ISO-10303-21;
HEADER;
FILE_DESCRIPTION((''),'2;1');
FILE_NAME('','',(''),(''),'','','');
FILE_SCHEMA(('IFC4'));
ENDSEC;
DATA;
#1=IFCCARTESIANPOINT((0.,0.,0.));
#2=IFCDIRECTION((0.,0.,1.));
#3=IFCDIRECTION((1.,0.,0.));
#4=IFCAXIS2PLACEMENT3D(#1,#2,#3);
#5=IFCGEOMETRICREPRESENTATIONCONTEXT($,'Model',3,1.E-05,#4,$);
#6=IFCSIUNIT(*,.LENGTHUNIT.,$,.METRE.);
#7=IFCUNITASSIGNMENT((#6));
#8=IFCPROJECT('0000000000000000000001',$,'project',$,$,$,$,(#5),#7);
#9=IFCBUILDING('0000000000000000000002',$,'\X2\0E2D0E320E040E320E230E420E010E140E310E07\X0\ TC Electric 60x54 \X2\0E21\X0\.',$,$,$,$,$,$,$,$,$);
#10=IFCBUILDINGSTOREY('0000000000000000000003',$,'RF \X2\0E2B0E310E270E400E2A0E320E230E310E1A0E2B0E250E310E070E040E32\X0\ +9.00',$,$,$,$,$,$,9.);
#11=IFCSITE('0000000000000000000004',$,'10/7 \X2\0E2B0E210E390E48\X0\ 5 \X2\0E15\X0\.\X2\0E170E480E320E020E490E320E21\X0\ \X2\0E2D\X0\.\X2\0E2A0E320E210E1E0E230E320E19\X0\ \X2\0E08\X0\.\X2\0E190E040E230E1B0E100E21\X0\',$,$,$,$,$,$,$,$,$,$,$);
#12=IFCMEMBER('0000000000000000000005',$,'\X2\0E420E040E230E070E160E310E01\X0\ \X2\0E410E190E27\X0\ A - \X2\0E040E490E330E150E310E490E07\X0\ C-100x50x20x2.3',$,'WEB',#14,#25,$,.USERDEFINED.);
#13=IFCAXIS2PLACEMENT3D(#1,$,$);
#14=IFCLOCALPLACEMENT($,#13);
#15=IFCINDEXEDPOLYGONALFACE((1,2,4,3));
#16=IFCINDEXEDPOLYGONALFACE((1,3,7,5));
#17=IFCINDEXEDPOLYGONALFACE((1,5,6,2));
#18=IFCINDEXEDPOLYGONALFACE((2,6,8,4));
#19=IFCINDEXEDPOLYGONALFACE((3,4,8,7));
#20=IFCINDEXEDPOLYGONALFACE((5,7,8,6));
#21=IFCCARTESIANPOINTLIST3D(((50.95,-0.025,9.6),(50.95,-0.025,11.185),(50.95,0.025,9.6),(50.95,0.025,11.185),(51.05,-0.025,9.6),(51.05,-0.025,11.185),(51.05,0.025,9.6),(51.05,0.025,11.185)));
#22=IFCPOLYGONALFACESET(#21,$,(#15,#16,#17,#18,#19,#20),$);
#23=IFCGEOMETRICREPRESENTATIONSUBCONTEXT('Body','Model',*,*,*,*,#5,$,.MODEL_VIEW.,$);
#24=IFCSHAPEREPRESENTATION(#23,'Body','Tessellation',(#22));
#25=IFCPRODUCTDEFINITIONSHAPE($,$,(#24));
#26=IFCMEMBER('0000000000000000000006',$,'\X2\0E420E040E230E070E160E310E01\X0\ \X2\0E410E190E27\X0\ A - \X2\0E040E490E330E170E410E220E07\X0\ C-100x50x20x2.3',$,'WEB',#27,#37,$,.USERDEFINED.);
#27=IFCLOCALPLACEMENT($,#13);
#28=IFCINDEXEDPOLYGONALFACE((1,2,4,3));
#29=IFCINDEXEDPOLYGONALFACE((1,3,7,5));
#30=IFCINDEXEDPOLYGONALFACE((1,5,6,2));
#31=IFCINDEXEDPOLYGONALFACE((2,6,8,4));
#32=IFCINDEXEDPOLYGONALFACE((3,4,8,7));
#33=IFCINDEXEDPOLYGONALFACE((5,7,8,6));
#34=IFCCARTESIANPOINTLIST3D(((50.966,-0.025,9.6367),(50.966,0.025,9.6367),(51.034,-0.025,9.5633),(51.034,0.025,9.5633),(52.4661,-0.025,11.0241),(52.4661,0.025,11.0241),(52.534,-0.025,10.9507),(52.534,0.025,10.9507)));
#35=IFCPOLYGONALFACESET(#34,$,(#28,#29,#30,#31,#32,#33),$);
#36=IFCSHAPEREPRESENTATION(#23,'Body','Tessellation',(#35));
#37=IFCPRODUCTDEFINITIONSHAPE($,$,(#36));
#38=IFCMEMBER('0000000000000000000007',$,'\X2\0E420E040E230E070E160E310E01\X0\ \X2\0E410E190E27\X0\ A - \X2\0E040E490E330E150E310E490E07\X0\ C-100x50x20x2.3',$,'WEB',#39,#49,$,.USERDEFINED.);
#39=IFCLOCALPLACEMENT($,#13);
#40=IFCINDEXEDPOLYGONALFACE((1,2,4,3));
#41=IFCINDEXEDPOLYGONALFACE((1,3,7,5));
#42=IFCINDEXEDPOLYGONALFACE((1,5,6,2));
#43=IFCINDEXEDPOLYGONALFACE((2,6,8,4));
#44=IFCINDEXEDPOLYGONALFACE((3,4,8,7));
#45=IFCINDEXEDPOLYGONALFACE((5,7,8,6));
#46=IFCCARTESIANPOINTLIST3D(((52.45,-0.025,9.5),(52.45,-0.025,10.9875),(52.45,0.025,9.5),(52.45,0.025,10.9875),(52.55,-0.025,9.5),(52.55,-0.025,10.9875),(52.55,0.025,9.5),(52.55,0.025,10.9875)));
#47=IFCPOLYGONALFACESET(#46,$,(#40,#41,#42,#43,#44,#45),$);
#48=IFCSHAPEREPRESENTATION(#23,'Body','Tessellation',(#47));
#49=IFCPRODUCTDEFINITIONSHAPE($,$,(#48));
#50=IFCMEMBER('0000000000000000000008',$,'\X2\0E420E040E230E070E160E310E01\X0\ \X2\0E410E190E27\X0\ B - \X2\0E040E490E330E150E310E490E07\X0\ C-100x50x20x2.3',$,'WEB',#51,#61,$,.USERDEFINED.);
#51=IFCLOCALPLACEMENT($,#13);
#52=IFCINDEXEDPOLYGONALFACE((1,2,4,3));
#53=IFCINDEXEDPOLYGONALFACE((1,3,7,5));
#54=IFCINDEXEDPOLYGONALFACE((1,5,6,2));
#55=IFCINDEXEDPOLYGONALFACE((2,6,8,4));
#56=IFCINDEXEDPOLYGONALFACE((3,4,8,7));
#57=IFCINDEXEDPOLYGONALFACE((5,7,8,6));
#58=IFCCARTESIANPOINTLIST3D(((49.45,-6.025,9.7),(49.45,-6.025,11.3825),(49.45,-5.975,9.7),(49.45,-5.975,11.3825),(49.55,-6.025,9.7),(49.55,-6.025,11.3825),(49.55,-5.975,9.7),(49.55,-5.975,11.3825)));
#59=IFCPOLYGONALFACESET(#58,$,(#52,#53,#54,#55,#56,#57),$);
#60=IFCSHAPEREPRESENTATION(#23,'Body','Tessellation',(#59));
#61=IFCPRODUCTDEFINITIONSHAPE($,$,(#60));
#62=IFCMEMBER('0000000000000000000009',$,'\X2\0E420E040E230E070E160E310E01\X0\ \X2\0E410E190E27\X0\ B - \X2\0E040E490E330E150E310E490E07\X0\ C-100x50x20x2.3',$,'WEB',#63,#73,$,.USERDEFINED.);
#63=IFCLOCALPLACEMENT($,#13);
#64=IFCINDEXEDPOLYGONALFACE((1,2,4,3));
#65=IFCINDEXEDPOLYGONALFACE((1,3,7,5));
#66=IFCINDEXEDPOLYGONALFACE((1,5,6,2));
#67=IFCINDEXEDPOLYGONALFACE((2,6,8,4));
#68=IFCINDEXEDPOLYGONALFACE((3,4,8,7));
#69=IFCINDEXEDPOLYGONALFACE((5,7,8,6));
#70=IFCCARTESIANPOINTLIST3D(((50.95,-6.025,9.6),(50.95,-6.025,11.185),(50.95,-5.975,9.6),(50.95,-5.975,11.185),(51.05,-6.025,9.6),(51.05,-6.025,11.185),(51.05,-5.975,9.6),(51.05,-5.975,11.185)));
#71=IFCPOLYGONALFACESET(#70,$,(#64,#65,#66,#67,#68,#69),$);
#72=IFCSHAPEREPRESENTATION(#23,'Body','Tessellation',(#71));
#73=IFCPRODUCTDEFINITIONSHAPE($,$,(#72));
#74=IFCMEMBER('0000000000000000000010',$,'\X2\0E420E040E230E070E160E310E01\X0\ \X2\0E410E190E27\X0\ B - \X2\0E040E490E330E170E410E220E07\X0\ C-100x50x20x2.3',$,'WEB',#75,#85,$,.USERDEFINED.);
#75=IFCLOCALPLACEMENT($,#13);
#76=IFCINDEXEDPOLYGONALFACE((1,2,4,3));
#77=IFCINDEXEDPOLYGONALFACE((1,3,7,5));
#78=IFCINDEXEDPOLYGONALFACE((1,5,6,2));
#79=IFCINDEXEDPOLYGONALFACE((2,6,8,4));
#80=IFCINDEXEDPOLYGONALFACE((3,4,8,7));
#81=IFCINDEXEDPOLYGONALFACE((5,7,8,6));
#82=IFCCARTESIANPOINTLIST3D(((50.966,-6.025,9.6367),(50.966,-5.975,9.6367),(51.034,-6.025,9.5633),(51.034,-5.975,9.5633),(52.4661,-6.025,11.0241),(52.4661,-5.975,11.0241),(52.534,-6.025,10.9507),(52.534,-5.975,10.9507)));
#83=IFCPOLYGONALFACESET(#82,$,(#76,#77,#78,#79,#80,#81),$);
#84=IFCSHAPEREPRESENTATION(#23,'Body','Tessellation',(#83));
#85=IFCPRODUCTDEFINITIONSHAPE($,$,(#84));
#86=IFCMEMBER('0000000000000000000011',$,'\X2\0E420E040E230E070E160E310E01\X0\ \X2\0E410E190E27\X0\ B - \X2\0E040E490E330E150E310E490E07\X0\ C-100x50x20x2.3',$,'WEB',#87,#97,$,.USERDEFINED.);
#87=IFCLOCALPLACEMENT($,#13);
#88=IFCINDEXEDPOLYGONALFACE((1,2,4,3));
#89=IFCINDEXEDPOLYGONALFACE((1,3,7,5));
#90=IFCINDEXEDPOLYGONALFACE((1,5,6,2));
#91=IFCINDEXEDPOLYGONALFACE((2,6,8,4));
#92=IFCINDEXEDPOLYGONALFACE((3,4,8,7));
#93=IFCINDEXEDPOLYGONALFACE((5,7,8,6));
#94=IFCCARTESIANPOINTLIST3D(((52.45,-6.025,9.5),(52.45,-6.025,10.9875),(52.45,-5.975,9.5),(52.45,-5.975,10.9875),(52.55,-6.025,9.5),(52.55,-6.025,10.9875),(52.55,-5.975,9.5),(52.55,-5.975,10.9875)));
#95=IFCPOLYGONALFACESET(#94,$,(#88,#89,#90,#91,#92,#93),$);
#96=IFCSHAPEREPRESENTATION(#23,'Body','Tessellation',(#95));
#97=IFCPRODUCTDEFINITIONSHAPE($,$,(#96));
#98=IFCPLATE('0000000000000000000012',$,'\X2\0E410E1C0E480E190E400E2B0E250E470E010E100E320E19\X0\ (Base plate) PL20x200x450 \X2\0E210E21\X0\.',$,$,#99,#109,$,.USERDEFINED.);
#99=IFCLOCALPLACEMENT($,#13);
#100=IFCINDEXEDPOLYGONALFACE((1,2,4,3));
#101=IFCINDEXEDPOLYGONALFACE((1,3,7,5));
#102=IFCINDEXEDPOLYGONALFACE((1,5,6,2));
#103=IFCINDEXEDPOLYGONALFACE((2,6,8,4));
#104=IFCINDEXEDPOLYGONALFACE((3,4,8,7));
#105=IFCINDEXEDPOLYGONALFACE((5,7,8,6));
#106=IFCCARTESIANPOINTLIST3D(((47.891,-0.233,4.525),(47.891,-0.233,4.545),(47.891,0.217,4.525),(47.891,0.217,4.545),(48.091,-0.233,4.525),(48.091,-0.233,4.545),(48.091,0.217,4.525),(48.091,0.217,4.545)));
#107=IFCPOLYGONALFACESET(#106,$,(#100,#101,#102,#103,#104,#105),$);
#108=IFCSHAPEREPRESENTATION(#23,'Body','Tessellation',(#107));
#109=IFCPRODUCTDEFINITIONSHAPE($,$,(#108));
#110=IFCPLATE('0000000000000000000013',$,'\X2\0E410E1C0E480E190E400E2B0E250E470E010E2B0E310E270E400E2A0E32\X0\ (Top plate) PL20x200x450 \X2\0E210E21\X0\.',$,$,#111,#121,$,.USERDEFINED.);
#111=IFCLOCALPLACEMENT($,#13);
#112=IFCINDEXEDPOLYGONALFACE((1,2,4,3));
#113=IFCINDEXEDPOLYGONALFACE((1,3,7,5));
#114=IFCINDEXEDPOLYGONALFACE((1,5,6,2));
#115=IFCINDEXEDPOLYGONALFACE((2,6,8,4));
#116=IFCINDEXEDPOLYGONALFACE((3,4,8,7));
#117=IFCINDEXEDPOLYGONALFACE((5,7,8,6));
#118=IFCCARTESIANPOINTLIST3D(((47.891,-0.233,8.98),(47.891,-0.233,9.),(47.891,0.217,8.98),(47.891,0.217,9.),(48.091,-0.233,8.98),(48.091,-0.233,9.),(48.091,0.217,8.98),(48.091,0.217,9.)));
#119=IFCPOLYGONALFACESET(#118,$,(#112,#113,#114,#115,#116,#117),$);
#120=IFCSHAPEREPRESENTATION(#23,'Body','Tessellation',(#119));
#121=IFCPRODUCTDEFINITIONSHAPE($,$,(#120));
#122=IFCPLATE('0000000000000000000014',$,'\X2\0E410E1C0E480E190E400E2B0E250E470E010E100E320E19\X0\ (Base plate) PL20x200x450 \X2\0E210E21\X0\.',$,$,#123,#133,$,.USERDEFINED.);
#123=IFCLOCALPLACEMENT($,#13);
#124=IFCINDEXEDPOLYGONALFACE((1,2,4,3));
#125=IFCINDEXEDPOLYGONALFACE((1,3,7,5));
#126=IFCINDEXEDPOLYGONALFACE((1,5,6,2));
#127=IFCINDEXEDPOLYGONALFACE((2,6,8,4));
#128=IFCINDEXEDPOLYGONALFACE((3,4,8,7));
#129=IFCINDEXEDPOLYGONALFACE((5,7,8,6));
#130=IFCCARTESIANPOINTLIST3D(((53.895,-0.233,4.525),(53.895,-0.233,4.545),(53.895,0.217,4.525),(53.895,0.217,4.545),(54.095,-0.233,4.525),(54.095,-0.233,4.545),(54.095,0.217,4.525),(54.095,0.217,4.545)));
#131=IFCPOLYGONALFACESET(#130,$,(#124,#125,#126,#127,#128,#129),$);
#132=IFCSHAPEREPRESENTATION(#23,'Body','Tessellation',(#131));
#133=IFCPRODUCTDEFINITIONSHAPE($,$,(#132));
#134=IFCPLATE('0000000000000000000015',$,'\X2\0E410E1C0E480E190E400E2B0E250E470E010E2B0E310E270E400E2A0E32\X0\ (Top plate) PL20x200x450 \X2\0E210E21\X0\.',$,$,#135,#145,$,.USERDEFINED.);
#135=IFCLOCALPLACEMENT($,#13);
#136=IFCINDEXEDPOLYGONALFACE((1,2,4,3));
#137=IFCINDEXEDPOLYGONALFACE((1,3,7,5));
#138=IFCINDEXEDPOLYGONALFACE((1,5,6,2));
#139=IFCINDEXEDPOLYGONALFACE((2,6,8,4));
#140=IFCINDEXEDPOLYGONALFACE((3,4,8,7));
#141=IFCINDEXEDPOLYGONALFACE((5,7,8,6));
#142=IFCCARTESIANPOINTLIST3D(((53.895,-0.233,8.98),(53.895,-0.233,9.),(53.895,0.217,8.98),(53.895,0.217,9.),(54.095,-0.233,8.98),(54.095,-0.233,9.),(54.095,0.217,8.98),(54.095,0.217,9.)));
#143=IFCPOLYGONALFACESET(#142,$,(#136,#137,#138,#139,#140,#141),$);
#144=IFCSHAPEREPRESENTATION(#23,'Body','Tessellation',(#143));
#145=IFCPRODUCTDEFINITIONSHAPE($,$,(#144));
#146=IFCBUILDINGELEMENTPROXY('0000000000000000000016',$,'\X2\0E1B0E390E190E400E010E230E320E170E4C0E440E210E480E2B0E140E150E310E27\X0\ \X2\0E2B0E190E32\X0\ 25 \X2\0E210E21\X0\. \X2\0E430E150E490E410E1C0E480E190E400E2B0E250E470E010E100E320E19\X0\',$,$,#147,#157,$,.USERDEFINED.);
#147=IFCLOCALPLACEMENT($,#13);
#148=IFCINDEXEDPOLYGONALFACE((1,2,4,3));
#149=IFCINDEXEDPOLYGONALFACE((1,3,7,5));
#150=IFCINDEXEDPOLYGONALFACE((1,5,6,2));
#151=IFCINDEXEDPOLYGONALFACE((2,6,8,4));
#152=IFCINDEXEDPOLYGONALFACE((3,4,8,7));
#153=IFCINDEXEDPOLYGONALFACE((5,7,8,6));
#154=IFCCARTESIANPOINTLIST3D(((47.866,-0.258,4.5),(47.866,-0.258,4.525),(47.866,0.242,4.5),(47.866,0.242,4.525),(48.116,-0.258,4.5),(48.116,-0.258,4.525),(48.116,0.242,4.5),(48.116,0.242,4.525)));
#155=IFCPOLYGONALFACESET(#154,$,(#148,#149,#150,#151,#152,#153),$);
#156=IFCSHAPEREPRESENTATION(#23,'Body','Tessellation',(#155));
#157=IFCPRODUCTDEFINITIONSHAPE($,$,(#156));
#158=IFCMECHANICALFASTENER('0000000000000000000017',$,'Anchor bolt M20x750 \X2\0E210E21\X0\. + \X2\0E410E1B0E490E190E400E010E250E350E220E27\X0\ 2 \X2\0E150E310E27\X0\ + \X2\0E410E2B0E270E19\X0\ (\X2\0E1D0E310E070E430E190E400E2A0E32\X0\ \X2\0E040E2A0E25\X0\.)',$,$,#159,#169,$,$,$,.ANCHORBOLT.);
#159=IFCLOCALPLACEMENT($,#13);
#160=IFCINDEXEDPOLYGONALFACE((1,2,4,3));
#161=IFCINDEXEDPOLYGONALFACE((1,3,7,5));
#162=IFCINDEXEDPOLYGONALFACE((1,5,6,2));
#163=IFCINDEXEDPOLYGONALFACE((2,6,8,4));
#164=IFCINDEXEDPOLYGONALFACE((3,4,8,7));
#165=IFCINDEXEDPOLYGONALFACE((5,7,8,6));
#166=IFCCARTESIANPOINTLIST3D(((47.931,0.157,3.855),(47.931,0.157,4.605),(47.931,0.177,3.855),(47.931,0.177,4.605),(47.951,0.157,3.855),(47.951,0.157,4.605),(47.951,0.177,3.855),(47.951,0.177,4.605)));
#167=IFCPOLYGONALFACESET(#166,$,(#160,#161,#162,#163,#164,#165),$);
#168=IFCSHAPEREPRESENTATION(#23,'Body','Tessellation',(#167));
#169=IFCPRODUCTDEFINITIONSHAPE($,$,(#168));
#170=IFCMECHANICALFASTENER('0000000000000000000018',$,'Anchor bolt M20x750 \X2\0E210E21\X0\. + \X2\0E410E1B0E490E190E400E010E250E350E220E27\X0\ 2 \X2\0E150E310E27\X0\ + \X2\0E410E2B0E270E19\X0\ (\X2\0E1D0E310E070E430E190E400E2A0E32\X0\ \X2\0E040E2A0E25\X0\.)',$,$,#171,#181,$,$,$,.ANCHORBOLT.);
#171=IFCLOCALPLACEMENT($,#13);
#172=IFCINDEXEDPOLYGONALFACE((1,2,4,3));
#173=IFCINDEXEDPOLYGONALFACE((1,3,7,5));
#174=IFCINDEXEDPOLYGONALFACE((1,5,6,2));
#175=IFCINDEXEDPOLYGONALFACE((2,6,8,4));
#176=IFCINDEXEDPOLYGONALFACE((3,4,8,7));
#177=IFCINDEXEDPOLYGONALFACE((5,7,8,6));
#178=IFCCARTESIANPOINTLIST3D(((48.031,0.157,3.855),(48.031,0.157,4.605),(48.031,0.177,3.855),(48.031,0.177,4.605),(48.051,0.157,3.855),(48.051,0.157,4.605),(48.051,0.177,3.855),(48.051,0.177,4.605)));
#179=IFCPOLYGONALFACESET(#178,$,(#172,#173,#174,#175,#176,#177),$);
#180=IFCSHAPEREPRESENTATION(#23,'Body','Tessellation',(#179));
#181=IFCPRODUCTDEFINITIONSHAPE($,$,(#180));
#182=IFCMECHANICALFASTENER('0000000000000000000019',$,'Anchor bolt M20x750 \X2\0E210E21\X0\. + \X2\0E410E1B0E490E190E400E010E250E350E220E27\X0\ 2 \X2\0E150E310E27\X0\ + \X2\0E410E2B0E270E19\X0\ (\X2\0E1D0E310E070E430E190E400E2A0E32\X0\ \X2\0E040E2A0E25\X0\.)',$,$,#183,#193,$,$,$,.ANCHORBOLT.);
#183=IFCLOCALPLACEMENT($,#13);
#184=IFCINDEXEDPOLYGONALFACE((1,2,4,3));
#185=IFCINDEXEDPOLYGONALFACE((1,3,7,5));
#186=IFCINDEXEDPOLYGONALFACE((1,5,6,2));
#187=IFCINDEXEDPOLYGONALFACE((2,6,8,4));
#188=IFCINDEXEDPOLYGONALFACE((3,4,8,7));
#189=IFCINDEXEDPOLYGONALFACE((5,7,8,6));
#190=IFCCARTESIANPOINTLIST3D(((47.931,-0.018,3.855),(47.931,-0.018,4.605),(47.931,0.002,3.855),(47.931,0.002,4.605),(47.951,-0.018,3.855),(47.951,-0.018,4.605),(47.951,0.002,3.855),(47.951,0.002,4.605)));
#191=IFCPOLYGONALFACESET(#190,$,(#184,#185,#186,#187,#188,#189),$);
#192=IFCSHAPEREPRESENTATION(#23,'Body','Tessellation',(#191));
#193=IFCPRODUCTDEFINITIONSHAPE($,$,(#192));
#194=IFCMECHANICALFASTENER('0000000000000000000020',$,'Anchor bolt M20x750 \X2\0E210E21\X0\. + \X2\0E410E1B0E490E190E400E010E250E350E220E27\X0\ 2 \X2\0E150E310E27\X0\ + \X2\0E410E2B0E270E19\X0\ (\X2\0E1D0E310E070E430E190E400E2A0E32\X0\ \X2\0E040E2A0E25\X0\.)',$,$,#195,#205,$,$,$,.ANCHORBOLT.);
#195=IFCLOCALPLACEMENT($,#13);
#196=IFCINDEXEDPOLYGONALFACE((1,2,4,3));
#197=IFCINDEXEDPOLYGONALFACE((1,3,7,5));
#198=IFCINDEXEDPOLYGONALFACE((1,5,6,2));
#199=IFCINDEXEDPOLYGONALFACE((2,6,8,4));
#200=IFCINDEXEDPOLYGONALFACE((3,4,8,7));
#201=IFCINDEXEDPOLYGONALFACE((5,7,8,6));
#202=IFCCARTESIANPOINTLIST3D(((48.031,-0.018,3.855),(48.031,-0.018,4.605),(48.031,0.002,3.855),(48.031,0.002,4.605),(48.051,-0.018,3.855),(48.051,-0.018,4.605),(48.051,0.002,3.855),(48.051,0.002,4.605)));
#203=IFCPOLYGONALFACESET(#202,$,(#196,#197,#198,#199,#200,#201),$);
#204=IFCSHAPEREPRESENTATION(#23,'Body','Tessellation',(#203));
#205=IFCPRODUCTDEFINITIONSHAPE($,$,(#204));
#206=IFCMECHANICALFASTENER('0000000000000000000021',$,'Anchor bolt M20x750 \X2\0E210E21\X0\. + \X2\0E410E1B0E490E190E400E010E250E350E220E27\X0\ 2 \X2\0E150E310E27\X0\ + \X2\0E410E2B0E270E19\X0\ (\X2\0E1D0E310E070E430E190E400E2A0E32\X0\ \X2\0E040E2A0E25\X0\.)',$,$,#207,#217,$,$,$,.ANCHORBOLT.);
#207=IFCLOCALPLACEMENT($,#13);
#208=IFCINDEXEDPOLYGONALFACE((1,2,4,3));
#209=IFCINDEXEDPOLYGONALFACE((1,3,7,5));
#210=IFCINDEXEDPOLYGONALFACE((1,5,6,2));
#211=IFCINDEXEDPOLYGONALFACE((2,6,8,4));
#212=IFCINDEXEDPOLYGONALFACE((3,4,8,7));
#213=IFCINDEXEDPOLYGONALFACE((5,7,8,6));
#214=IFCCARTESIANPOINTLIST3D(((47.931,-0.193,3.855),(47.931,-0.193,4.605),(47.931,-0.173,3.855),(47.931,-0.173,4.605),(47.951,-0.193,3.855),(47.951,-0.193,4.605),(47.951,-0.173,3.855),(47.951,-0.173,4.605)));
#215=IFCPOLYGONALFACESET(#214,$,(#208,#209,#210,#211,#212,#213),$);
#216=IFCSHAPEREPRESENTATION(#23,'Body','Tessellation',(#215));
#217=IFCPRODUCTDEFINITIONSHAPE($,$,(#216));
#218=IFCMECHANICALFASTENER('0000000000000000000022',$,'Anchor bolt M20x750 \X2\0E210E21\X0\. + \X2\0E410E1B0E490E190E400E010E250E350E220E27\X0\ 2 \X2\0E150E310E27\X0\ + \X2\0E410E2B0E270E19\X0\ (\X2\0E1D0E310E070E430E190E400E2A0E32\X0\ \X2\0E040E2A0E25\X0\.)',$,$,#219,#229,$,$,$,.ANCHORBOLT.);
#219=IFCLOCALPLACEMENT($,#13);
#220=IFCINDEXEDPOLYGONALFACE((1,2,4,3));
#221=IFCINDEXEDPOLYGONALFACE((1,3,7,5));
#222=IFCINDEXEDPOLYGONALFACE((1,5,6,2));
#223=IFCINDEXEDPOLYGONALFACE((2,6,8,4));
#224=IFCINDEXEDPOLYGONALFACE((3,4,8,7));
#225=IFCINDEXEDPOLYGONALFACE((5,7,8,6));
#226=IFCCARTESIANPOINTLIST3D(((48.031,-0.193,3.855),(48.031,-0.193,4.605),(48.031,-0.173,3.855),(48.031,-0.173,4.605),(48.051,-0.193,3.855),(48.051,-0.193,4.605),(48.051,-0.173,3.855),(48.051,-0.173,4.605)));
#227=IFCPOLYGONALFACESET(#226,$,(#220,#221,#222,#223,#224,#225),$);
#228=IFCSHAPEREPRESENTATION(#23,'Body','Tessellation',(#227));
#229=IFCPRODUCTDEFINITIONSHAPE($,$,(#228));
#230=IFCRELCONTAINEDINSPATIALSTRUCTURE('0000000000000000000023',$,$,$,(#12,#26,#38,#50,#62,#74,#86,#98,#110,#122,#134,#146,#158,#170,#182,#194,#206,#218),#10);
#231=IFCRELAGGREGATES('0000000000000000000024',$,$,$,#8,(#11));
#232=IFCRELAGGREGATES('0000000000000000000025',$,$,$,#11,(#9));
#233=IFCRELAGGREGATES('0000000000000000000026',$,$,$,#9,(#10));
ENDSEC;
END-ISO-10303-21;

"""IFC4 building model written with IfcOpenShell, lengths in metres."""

from ifc_helpers import new_model, si_unit, frame, origin, origin_with_axes, origin_2d, place, context, subcontext, project, spatial, rectangle, extrude, element, save


model = new_model("IFC4")

# Units and contexts
model_context = context("Model", 3, precision=1e-05, world=origin_with_axes())
body_context = subcontext(model_context, "Body", "Model", "MODEL_VIEW")
ifc_project = project(units=[si_unit("LENGTHUNIT", "METRE")], contexts=[model_context])

# Site, building, storey
site = spatial("IfcSite", under=ifc_project, Name="10/7 หมู่ 5 ต.ท่าข้าม อ.สามพราน จ.นครปฐม")
building = spatial("IfcBuilding", under=site, Name="อาคารโกดัง TC Electric 60x54 ม.")
storey = spatial("IfcBuildingStorey", under=building, Name="RF หัวเสารับหลังคา +9.00", Elevation=9.0)

# Members
member_1_placement = place(None, frame((51.0, 0.0, 9.6), z_axis=(0.0, 0.0, 1.0), x_axis=(0.0, 1.0, 0.0)))
element("IfcMember", 1, at=member_1_placement, inside=storey, Name="โครงถัก แนว A - ค้ำตั้ง C-100x50x20x2.3", ObjectType="WEB", PredefinedType="USERDEFINED", context=body_context, shape_type="SweptSolid", body=[
    extrude(rectangle(XDim=0.05, YDim=0.1, at=origin_2d()), origin(), (0.0, 0.0, 1.0), 1.585),
])
member_2_placement = place(None, frame((51.0, 0.0, 9.6), z_axis=(0.7341, 0.0, 0.679), x_axis=(0.0, -1.0, 0.0)))
element("IfcMember", 2, at=member_2_placement, inside=storey, Name="โครงถัก แนว A - ค้ำทแยง C-100x50x20x2.3", ObjectType="WEB", PredefinedType="USERDEFINED", context=body_context, shape_type="SweptSolid", body=[
    extrude(rectangle(XDim=0.05, YDim=0.1, at=origin_2d()), origin(), (0.0, 0.0, 1.0), 2.0433),
])
member_3_placement = place(None, frame((52.5, 0.0, 9.5), z_axis=(0.0, 0.0, 1.0), x_axis=(0.0, 1.0, 0.0)))
element("IfcMember", 3, at=member_3_placement, inside=storey, Name="โครงถัก แนว A - ค้ำตั้ง C-100x50x20x2.3", ObjectType="WEB", PredefinedType="USERDEFINED", context=body_context, shape_type="SweptSolid", body=[
    extrude(rectangle(XDim=0.05, YDim=0.1, at=origin_2d()), origin(), (0.0, 0.0, 1.0), 1.4875),
])
member_4_placement = place(None, frame((49.5, -6.0, 9.7), z_axis=(0.0, 0.0, 1.0), x_axis=(0.0, 1.0, 0.0)))
element("IfcMember", 4, at=member_4_placement, inside=storey, Name="โครงถัก แนว B - ค้ำตั้ง C-100x50x20x2.3", ObjectType="WEB", PredefinedType="USERDEFINED", context=body_context, shape_type="SweptSolid", body=[
    extrude(rectangle(XDim=0.05, YDim=0.1, at=origin_2d()), origin(), (0.0, 0.0, 1.0), 1.6825),
])
member_5_placement = place(None, frame((51.0, -6.0, 9.6), z_axis=(0.0, 0.0, 1.0), x_axis=(0.0, 1.0, 0.0)))
element("IfcMember", 5, at=member_5_placement, inside=storey, Name="โครงถัก แนว B - ค้ำตั้ง C-100x50x20x2.3", ObjectType="WEB", PredefinedType="USERDEFINED", context=body_context, shape_type="SweptSolid", body=[
    extrude(rectangle(XDim=0.05, YDim=0.1, at=origin_2d()), origin(), (0.0, 0.0, 1.0), 1.585),
])
member_6_placement = place(None, frame((51.0, -6.0, 9.6), z_axis=(0.7341, 0.0, 0.679), x_axis=(0.0, -1.0, 0.0)))
element("IfcMember", 6, at=member_6_placement, inside=storey, Name="โครงถัก แนว B - ค้ำทแยง C-100x50x20x2.3", ObjectType="WEB", PredefinedType="USERDEFINED", context=body_context, shape_type="SweptSolid", body=[
    extrude(rectangle(XDim=0.05, YDim=0.1, at=origin_2d()), origin(), (0.0, 0.0, 1.0), 2.0433),
])
member_7_placement = place(None, frame((52.5, -6.0, 9.5), z_axis=(0.0, 0.0, 1.0), x_axis=(0.0, 1.0, 0.0)))
element("IfcMember", 7, at=member_7_placement, inside=storey, Name="โครงถัก แนว B - ค้ำตั้ง C-100x50x20x2.3", ObjectType="WEB", PredefinedType="USERDEFINED", context=body_context, shape_type="SweptSolid", body=[
    extrude(rectangle(XDim=0.05, YDim=0.1, at=origin_2d()), origin(), (0.0, 0.0, 1.0), 1.4875),
])

# Plates
for number, where, z_axis, x_axis, name in (
    (8, (47.991, -0.008, 4.525), (0.0, 0.0, 1.0), (1.0, 0.0, 0.0), "แผ่นเหล็กฐาน (Base plate) PL20x200x450 มม."),
    (9, (47.991, -0.008, 8.98), (0.0, 0.0, 1.0), (1.0, 0.0, 0.0), "แผ่นเหล็กหัวเสา (Top plate) PL20x200x450 มม."),
    (10, (53.995, -0.008, 4.525), (0.0, 0.0, 1.0), (1.0, 0.0, 0.0), "แผ่นเหล็กฐาน (Base plate) PL20x200x450 มม."),
    (11, (53.995, -0.008, 8.98), (0.0, 0.0, 1.0), (1.0, 0.0, 0.0), "แผ่นเหล็กหัวเสา (Top plate) PL20x200x450 มม."),
):
    element("IfcPlate", number, at=place(None, frame(where, z_axis=z_axis, x_axis=x_axis)), inside=storey, Name=name, PredefinedType="USERDEFINED", context=body_context, shape_type="SweptSolid", body=[
        extrude(rectangle(XDim=0.2, YDim=0.45, at=origin_2d()), origin(), (0.0, 0.0, 1.0), 0.02),
    ])

# Building element proxy
proxy_1_placement = place(None, frame((47.991, -0.008, 4.5), z_axis=(0.0, 0.0, 1.0), x_axis=(1.0, 0.0, 0.0)))
element("IfcBuildingElementProxy", 12, at=proxy_1_placement, inside=storey, Name="ปูนเกราท์ไม่หดตัว หนา 25 มม. ใต้แผ่นเหล็กฐาน", PredefinedType="USERDEFINED", context=body_context, shape_type="SweptSolid", body=[
    extrude(rectangle(XDim=0.25, YDim=0.5, at=origin_2d()), origin(), (0.0, 0.0, 1.0), 0.025),
])

# Mechanical fasteners
for number, where, z_axis, x_axis, name in (
    (13, (47.941, 0.167, 3.855), (0.0, 0.0, 1.0), (1.0, 0.0, 0.0), "Anchor bolt M20x750 มม. + แป้นเกลียว 2 ตัว + แหวน (ฝังในเสา คสล.)"),
    (14, (48.041, 0.167, 3.855), (0.0, 0.0, 1.0), (1.0, 0.0, 0.0), "Anchor bolt M20x750 มม. + แป้นเกลียว 2 ตัว + แหวน (ฝังในเสา คสล.)"),
    (15, (47.941, -0.008, 3.855), (0.0, 0.0, 1.0), (1.0, 0.0, 0.0), "Anchor bolt M20x750 มม. + แป้นเกลียว 2 ตัว + แหวน (ฝังในเสา คสล.)"),
    (16, (48.041, -0.008, 3.855), (0.0, 0.0, 1.0), (1.0, 0.0, 0.0), "Anchor bolt M20x750 มม. + แป้นเกลียว 2 ตัว + แหวน (ฝังในเสา คสล.)"),
    (17, (47.941, -0.183, 3.855), (0.0, 0.0, 1.0), (1.0, 0.0, 0.0), "Anchor bolt M20x750 มม. + แป้นเกลียว 2 ตัว + แหวน (ฝังในเสา คสล.)"),
    (18, (48.041, -0.183, 3.855), (0.0, 0.0, 1.0), (1.0, 0.0, 0.0), "Anchor bolt M20x750 มม. + แป้นเกลียว 2 ตัว + แหวน (ฝังในเสา คสล.)"),
):
    element("IfcMechanicalFastener", number, at=place(None, frame(where, z_axis=z_axis, x_axis=x_axis)), inside=storey, Name=name, PredefinedType="ANCHORBOLT", context=body_context, shape_type="SweptSolid", body=[
        extrude(rectangle(XDim=0.02, YDim=0.02, at=origin_2d()), origin(), (0.0, 0.0, 1.0), 0.75),
    ])

save(model, "model.ifc")
